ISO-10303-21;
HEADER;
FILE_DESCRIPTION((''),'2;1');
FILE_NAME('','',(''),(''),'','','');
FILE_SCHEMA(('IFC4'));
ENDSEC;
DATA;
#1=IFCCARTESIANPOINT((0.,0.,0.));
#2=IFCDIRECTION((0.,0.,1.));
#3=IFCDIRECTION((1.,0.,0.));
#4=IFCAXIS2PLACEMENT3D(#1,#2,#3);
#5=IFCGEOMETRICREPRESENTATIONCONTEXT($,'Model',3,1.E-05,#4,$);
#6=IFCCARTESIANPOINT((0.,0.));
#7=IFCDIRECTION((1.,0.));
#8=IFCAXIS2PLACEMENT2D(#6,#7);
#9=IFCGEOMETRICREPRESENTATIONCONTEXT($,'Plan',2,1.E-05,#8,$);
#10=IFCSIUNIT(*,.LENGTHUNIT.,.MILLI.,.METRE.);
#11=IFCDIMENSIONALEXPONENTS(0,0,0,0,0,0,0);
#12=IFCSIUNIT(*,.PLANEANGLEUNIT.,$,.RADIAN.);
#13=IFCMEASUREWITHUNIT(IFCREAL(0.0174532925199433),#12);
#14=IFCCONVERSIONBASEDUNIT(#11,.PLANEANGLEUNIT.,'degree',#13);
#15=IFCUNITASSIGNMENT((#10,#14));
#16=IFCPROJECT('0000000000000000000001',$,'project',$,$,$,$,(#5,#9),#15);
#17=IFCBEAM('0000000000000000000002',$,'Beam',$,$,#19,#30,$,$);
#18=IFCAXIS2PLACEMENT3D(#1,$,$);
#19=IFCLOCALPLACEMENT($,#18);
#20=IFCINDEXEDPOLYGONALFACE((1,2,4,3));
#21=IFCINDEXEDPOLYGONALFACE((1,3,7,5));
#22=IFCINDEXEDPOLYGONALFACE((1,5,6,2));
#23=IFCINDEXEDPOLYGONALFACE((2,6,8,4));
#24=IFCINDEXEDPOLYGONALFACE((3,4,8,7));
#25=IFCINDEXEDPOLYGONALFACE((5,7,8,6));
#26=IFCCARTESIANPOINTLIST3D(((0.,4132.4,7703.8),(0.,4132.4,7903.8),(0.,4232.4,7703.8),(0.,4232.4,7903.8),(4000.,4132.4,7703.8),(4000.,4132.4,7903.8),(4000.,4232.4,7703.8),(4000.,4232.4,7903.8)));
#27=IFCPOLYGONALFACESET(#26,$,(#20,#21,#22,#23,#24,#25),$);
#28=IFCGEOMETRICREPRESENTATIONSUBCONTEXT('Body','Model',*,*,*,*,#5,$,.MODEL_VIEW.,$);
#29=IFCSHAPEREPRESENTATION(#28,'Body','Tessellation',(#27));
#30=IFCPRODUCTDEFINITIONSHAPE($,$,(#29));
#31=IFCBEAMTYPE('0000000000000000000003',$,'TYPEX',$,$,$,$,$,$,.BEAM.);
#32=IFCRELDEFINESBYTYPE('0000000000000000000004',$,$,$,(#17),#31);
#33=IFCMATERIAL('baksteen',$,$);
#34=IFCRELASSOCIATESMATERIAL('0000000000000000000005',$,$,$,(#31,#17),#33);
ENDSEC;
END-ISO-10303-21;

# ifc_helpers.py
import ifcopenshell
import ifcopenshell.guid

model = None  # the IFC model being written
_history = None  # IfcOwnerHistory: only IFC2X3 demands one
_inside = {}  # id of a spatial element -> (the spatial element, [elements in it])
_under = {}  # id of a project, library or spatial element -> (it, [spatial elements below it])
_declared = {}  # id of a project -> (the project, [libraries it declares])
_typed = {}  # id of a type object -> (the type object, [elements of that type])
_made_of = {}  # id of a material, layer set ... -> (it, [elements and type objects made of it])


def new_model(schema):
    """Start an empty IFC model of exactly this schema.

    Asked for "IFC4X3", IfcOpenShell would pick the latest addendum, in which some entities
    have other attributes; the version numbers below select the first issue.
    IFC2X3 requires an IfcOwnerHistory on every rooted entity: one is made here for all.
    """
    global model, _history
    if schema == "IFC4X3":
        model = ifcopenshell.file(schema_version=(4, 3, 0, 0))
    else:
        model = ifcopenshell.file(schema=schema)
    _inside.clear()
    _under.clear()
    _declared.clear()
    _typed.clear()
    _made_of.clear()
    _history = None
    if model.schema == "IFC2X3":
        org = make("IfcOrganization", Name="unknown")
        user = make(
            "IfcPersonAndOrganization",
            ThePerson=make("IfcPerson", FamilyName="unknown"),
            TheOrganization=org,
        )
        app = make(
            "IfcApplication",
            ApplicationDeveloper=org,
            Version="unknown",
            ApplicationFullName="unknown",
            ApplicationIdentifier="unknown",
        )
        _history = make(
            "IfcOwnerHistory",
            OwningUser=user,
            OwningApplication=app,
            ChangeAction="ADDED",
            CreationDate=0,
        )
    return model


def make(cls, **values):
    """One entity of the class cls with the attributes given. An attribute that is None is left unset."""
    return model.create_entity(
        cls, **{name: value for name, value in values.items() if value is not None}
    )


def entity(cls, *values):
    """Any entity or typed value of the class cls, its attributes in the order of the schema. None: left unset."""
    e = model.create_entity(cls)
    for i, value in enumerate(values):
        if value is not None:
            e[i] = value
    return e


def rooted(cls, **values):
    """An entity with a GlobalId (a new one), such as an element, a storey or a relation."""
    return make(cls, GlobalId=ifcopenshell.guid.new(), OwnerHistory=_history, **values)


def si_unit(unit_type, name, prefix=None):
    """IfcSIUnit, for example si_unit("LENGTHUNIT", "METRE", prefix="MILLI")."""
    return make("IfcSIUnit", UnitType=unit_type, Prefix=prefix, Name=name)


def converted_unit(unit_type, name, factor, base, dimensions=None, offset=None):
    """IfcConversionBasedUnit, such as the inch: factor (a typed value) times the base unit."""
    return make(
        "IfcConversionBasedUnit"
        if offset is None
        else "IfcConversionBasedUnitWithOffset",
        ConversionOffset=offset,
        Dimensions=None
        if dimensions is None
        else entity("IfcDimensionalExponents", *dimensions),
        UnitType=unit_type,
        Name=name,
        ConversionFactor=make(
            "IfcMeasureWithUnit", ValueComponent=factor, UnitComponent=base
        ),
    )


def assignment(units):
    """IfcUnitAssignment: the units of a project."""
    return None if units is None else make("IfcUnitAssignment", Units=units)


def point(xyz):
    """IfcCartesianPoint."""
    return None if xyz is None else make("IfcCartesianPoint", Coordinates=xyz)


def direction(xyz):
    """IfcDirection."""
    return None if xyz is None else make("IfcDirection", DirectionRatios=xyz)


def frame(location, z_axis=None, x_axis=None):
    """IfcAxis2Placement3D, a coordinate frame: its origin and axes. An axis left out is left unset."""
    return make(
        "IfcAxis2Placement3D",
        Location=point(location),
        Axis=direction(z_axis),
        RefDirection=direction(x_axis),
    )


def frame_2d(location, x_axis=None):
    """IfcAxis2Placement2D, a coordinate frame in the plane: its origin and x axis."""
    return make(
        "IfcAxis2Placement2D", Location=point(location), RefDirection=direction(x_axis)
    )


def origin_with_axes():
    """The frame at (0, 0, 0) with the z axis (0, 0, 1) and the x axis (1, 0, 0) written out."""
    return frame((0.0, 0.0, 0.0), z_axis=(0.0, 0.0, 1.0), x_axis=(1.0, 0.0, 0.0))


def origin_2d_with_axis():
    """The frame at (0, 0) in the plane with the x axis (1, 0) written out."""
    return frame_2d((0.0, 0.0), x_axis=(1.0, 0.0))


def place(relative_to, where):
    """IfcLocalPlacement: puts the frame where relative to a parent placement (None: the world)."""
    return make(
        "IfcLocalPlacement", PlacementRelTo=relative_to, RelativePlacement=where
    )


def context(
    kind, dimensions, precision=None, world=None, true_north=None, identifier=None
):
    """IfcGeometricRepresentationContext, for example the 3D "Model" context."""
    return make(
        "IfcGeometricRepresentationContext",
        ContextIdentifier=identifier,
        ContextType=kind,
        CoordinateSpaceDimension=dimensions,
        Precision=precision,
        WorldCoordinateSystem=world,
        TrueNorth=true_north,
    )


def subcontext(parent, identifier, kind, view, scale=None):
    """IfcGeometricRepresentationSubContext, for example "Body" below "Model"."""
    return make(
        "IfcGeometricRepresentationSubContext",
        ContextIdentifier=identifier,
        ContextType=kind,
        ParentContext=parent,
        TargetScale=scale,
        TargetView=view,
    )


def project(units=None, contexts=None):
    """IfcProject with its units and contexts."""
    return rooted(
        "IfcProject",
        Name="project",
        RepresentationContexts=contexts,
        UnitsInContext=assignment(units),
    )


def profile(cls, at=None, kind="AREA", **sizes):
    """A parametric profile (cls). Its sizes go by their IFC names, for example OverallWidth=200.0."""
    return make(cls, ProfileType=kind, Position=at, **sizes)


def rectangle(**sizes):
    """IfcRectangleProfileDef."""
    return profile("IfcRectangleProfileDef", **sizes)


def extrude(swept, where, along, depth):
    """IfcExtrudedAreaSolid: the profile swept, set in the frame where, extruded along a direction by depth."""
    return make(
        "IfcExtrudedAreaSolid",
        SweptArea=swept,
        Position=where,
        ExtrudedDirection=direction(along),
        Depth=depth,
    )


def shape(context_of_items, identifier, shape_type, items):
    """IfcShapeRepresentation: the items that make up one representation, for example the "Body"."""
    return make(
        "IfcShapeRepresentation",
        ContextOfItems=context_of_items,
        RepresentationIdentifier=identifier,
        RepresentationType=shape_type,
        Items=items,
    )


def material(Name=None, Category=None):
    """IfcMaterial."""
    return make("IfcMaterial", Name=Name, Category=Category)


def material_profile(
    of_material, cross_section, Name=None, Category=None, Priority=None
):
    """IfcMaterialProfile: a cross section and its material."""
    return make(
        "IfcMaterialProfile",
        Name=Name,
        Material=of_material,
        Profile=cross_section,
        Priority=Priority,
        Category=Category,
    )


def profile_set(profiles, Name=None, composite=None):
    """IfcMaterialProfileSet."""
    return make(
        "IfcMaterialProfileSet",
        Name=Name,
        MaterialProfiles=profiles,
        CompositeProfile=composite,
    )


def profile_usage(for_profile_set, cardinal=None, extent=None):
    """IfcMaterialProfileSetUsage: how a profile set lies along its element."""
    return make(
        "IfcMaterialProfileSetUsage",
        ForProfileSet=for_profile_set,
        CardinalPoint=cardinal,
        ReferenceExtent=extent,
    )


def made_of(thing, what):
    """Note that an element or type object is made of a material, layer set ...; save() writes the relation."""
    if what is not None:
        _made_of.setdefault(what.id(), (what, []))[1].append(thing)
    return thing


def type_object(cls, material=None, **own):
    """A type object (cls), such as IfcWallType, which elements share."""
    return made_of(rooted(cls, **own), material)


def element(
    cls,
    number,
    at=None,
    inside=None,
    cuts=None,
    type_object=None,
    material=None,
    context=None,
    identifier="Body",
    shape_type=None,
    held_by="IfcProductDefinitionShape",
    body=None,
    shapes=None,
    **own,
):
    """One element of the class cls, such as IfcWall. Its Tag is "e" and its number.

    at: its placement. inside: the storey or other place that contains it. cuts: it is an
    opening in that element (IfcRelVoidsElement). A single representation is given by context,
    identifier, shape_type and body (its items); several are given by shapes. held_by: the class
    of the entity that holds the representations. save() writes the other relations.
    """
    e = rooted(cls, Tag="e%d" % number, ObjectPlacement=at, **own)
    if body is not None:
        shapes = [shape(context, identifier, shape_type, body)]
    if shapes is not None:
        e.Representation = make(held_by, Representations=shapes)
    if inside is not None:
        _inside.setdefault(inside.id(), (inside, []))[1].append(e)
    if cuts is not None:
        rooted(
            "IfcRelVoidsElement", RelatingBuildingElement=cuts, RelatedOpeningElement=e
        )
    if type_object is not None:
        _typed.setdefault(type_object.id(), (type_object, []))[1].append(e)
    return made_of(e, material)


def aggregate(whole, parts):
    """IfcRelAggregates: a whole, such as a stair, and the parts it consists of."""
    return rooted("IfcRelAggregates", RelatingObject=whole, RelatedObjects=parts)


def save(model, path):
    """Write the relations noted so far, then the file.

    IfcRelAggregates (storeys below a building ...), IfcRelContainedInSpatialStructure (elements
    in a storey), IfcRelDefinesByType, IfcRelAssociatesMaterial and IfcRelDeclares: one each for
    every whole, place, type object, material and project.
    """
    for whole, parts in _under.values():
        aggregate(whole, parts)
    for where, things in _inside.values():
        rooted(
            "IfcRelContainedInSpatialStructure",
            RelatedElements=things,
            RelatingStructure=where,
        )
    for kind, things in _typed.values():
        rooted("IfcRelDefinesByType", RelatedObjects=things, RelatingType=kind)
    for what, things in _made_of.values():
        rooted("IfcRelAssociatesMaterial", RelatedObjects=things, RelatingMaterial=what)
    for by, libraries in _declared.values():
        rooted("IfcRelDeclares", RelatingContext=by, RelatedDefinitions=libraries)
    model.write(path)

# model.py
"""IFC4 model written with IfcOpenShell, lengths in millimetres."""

from ifc_helpers import new_model, entity, si_unit, converted_unit, frame, origin_with_axes, origin_2d_with_axis, place, context, subcontext, project, rectangle, extrude, material, material_profile, profile_set, profile_usage, type_object, element, save


model = new_model("IFC4")

# Units and contexts
model_context = context("Model", 3, precision=1e-05, world=origin_with_axes())
plan_context = context("Plan", 2, precision=1e-05, world=origin_2d_with_axis())
body_context = subcontext(model_context, "Body", "Model", "MODEL_VIEW")
ifc_project = project(units=[si_unit("LENGTHUNIT", "METRE", prefix="MILLI"), converted_unit("PLANEANGLEUNIT", "degree", entity("IfcReal", 0.0174532925199433), si_unit("PLANEANGLEUNIT", "RADIAN"), dimensions=[0, 0, 0, 0, 0, 0, 0])], contexts=[model_context, plan_context])

# Beam
ifc_material = material(Name="baksteen")
ifc_material_profile = material_profile(ifc_material, rectangle(XDim=100.0, YDim=200.0))
ifc_profile_set = profile_set([ifc_material_profile])
ifc_profile_usage = profile_usage(ifc_profile_set, cardinal=5)
beam_type = type_object("IfcBeamType", Name="TYPEX", PredefinedType="BEAM", material=ifc_profile_set)
beam_placement = place(None, frame((0.0, 4182.4, 7803.8), z_axis=(1.0, 0.0, 0.0), x_axis=(0.0, 1.0, 0.0)))
element("IfcBeam", 1, at=beam_placement, type_object=beam_type, material=ifc_profile_usage, Name="Beam", context=body_context, shape_type="SweptSolid", body=[
    extrude(rectangle(XDim=100.0, YDim=200.0), origin_with_axes(), (0.0, 0.0, 1.0), 4000.0),
])

save(model, "model.ifc")
